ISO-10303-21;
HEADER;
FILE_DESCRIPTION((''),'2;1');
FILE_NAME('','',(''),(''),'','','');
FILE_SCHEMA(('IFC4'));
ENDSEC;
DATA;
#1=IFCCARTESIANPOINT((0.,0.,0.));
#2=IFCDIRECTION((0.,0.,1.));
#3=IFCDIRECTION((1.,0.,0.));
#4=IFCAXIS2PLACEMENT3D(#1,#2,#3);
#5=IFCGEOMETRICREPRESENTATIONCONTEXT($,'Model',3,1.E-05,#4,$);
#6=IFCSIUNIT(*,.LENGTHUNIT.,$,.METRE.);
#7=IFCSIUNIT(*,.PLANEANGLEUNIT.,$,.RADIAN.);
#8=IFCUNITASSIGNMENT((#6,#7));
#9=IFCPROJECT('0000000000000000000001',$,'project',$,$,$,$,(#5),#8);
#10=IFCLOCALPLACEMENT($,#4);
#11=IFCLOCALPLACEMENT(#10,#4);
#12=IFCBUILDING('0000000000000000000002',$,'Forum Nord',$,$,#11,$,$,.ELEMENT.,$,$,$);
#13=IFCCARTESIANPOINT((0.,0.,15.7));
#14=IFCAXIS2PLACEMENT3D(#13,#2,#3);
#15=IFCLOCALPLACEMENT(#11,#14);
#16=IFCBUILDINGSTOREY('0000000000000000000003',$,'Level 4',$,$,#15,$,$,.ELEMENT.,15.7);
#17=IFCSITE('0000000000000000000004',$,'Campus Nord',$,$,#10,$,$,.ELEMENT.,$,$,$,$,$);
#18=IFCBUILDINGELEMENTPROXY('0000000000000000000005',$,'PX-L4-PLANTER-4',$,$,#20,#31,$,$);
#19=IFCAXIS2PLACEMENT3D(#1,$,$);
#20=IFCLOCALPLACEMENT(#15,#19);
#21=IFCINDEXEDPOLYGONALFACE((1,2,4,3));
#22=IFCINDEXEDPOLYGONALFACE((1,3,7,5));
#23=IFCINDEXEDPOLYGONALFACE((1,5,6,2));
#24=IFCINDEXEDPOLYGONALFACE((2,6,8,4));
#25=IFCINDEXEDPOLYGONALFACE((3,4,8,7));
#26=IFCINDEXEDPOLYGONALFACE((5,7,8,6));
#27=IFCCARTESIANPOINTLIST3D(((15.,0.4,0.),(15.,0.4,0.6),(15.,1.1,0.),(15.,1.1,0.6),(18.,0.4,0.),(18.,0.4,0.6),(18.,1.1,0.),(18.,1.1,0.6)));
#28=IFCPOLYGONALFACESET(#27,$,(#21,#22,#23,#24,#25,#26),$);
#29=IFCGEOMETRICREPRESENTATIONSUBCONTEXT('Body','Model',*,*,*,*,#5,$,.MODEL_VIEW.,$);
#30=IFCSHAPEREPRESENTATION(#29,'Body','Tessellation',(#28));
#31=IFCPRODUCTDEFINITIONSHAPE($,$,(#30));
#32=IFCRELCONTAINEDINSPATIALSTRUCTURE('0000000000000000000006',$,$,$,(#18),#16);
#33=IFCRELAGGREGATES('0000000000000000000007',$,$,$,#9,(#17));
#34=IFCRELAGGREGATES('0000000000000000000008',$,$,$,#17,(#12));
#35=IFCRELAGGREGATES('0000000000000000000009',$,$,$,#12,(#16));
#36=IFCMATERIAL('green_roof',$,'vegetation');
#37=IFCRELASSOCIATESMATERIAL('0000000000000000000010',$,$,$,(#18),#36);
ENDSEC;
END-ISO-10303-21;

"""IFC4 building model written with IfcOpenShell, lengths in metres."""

from ifc_helpers import new_model, si_unit, frame, origin_with_axes, place, context, subcontext, project, spatial, polyline, outline, extrude, material, element, save


model = new_model("IFC4")

# Units and contexts
model_context = context("Model", 3, precision=1e-05, world=origin_with_axes())
body_context = subcontext(model_context, "Body", "Model", "MODEL_VIEW")
ifc_project = project(units=[si_unit("LENGTHUNIT", "METRE"), si_unit("PLANEANGLEUNIT", "RADIAN")], contexts=[model_context])

# Site, building, storey
site_placement = place(None, origin_with_axes())
site = spatial("IfcSite", under=ifc_project, at=site_placement, Name="Campus Nord", CompositionType="ELEMENT")
building_placement = place(site_placement, origin_with_axes())
building = spatial("IfcBuilding", under=site, at=building_placement, Name="Forum Nord", CompositionType="ELEMENT")
storey_placement = place(building_placement, frame((0.0, 0.0, 15.7), z_axis=(0.0, 0.0, 1.0), x_axis=(1.0, 0.0, 0.0)))
storey = spatial("IfcBuildingStorey", under=building, at=storey_placement, Name="Level 4", CompositionType="ELEMENT", Elevation=15.7)

# Building element proxy
ifc_material_1 = material(Name="green_roof", Category="vegetation")
proxy_1_placement = place(storey_placement, origin_with_axes())
element("IfcBuildingElementProxy", 1, at=proxy_1_placement, inside=storey, material=ifc_material_1, Name="PX-L4-PLANTER-4", context=body_context, shape_type="SweptSolid", body=[
    extrude(outline(polyline([(15.0, 0.4), (18.0, 0.4), (18.0, 1.1), (15.0, 1.1), (15.0, 0.4)])), origin_with_axes(), (0.0, 0.0, 1.0), 0.6),
])

save(model, "model.ifc")
